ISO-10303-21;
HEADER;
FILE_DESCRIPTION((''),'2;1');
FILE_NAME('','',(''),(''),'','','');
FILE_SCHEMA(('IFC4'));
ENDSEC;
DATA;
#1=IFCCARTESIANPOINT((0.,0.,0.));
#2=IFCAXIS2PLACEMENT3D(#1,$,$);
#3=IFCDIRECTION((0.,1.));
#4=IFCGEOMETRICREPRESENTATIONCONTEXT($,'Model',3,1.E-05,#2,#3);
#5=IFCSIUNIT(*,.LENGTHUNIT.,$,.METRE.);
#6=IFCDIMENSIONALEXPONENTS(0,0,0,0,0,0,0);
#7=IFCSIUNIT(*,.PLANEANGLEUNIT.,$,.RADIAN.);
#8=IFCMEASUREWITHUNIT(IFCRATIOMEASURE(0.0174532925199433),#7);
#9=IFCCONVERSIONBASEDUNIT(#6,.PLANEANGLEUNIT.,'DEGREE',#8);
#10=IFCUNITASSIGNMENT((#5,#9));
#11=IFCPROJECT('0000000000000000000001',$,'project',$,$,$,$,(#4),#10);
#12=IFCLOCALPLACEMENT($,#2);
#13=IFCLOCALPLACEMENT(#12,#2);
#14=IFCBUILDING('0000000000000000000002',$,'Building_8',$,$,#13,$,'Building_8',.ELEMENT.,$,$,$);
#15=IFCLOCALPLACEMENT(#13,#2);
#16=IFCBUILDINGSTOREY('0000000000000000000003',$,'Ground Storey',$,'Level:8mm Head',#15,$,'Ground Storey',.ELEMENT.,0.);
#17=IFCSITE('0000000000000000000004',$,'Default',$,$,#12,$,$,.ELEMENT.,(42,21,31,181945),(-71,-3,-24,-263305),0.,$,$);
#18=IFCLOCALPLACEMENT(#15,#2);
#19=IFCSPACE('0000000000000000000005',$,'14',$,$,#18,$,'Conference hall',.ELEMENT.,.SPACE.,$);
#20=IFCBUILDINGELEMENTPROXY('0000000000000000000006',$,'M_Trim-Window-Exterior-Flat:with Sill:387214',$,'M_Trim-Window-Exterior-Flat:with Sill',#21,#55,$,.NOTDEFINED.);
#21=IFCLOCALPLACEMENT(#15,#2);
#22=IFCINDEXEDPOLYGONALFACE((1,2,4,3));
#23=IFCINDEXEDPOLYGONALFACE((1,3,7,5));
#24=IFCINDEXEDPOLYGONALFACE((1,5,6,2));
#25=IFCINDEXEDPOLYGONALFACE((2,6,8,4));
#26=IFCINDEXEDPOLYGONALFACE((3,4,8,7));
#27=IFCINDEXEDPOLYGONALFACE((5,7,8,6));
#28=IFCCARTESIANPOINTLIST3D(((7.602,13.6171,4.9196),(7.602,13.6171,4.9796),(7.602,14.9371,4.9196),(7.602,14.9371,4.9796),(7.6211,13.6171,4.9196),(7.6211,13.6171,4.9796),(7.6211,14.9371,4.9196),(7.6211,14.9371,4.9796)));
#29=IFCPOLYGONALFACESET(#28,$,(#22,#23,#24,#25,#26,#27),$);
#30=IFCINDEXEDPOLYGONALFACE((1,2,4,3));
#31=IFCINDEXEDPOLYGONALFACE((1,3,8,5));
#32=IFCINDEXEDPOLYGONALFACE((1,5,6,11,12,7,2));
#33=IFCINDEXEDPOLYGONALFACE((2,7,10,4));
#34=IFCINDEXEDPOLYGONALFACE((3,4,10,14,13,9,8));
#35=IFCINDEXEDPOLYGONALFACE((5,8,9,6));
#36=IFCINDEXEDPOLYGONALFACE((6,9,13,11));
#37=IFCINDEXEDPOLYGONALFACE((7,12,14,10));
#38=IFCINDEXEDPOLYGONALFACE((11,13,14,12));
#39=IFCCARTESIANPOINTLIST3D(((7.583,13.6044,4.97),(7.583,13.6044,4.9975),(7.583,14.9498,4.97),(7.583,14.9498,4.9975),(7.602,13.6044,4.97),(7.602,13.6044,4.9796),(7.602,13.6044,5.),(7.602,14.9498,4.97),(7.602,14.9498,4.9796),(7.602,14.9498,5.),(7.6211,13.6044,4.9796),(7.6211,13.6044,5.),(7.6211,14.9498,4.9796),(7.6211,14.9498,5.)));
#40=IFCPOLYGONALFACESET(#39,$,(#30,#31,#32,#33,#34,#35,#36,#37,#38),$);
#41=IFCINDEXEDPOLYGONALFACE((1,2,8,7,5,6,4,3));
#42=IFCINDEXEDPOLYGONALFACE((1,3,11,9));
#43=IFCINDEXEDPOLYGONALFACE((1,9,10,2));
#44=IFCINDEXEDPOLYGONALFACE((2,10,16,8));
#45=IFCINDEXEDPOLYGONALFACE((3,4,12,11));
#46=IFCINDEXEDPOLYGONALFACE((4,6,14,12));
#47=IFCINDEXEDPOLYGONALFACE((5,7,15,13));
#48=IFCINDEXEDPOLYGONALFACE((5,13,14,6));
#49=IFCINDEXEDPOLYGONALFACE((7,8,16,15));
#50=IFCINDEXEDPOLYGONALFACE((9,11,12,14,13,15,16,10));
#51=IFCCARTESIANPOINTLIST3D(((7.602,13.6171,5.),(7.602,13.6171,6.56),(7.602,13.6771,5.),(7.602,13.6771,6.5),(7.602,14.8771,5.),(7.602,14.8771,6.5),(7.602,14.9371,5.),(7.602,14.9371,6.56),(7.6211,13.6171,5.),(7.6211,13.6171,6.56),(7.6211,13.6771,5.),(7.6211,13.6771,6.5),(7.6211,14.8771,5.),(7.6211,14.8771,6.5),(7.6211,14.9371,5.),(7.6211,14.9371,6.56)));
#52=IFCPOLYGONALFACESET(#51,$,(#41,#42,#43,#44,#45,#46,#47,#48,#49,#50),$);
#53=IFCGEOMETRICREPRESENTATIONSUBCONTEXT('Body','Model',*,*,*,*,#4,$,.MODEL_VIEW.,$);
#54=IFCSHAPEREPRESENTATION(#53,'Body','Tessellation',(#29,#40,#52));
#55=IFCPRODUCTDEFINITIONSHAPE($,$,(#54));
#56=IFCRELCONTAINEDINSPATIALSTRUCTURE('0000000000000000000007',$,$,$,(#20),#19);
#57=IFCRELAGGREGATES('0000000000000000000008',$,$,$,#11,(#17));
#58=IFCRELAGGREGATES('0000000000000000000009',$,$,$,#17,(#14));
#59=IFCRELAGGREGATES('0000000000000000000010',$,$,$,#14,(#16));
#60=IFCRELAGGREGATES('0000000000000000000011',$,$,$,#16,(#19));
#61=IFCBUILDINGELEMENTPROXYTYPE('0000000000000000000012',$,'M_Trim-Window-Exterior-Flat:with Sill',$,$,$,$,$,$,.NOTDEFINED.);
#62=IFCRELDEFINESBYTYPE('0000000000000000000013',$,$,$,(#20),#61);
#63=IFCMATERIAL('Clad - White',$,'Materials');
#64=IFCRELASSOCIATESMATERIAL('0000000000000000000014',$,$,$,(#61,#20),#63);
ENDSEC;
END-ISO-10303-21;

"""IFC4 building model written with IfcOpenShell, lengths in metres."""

from ifc_helpers import new_model, entity, si_unit, converted_unit, direction, frame, origin, place, context, subcontext, project, spatial, indexed_curve, outline, extrude, source, transform, mapped, material, type_object, type_shapes, element, save


model = new_model("IFC4")

# Units and contexts
model_context = context("Model", 3, precision=1e-05, world=origin(), true_north=direction((0.0, 1.0)))
body_context = subcontext(model_context, "Body", "Model", "MODEL_VIEW")
ifc_project = project(units=[si_unit("LENGTHUNIT", "METRE"), converted_unit("PLANEANGLEUNIT", "DEGREE", entity("IfcRatioMeasure", 0.0174532925199433), si_unit("PLANEANGLEUNIT", "RADIAN"), dimensions=[0, 0, 0, 0, 0, 0, 0])], contexts=[model_context])

# Site, building, storey
site_placement = place(None, origin())
site = spatial("IfcSite", under=ifc_project, at=site_placement, Name="Default", CompositionType="ELEMENT", RefLatitude=(42, 21, 31, 181945), RefLongitude=(-71, -3, -24, -263305), RefElevation=0.0)
building_placement = place(site_placement, origin())
building = spatial("IfcBuilding", under=site, at=building_placement, Name="Building_8", LongName="Building_8", CompositionType="ELEMENT")
storey_placement = place(building_placement, origin())
storey = spatial("IfcBuildingStorey", under=building, at=storey_placement, Name="Ground Storey", ObjectType="Level:8mm Head", LongName="Ground Storey", CompositionType="ELEMENT", Elevation=0.0)

# Shared definitions
ifc_material_1 = material(Name="Clad - White", Category="Materials")

# Shared definitions
space_1_placement = place(storey_placement, origin())
space_1 = spatial("IfcSpace", under=storey, at=space_1_placement, Name="14", LongName="Conference hall", CompositionType="ELEMENT", PredefinedType="SPACE")

# Building element proxy
building_element_proxy_type_1 = type_object("IfcBuildingElementProxyType", Name="M_Trim-Window-Exterior-Flat:with Sill", PredefinedType="NOTDEFINED", material=ifc_material_1)
shared_shape_1 = source(origin(), body_context, "Body", "SweptSolid", [
    extrude(outline(indexed_curve([(-0.66, -0.03), (0.66, -0.03), (0.66, 0.03), (-0.66, 0.03), (-0.66, -0.03)], self_intersect=False)), frame((0.0, -1.5504, 0.0), z_axis=(0.0, 0.0, 1.0), x_axis=(-1.0, 0.0, 0.0)), (0.0, 0.0, 1.0), 0.0191),
    extrude(outline(indexed_curve([(-0.019, -0.0152), (0.0, -0.0152), (0.0, -0.0057), (0.019, -0.0057), (0.019, 0.0148), (0.0, 0.0148), (-0.019, 0.0123), (-0.019, -0.0152)], self_intersect=False)), frame((-0.6727, -1.5148, 0.019), z_axis=(1.0, 0.0, 0.0), x_axis=(0.0, 0.0, -1.0)), (0.0, 0.0, 1.0), 1.3454),
    extrude(outline(indexed_curve([(-0.795, -0.66), (0.765, -0.66), (0.765, -0.6), (-0.735, -0.6), (-0.735, 0.6), (0.765, 0.6), (0.765, 0.66), (-0.795, 0.66), (-0.795, -0.66)], self_intersect=False)), frame((0.0, -0.735, 0.0), z_axis=(0.0, 0.0, 1.0), x_axis=(0.0, -1.0, 0.0)), (0.0, 0.0, 1.0), 0.0191),
])
type_shapes(building_element_proxy_type_1, [shared_shape_1])
proxy_1_placement = place(space_1_placement, frame((7.6211, 14.2771, 6.5), z_axis=(-1.0, 0.0, 0.0), x_axis=(0.0, -1.0, 0.0)))
element("IfcBuildingElementProxy", 1, at=proxy_1_placement, inside=space_1, type_object=building_element_proxy_type_1, material=ifc_material_1, Name="M_Trim-Window-Exterior-Flat:with Sill:387214", ObjectType="M_Trim-Window-Exterior-Flat:with Sill", PredefinedType="NOTDEFINED", context=body_context, shape_type="MappedRepresentation", body=[
    mapped(shared_shape_1, transform((0.0, 0.0, 0.0), scale=1.0)),
])

save(model, "model.ifc")
